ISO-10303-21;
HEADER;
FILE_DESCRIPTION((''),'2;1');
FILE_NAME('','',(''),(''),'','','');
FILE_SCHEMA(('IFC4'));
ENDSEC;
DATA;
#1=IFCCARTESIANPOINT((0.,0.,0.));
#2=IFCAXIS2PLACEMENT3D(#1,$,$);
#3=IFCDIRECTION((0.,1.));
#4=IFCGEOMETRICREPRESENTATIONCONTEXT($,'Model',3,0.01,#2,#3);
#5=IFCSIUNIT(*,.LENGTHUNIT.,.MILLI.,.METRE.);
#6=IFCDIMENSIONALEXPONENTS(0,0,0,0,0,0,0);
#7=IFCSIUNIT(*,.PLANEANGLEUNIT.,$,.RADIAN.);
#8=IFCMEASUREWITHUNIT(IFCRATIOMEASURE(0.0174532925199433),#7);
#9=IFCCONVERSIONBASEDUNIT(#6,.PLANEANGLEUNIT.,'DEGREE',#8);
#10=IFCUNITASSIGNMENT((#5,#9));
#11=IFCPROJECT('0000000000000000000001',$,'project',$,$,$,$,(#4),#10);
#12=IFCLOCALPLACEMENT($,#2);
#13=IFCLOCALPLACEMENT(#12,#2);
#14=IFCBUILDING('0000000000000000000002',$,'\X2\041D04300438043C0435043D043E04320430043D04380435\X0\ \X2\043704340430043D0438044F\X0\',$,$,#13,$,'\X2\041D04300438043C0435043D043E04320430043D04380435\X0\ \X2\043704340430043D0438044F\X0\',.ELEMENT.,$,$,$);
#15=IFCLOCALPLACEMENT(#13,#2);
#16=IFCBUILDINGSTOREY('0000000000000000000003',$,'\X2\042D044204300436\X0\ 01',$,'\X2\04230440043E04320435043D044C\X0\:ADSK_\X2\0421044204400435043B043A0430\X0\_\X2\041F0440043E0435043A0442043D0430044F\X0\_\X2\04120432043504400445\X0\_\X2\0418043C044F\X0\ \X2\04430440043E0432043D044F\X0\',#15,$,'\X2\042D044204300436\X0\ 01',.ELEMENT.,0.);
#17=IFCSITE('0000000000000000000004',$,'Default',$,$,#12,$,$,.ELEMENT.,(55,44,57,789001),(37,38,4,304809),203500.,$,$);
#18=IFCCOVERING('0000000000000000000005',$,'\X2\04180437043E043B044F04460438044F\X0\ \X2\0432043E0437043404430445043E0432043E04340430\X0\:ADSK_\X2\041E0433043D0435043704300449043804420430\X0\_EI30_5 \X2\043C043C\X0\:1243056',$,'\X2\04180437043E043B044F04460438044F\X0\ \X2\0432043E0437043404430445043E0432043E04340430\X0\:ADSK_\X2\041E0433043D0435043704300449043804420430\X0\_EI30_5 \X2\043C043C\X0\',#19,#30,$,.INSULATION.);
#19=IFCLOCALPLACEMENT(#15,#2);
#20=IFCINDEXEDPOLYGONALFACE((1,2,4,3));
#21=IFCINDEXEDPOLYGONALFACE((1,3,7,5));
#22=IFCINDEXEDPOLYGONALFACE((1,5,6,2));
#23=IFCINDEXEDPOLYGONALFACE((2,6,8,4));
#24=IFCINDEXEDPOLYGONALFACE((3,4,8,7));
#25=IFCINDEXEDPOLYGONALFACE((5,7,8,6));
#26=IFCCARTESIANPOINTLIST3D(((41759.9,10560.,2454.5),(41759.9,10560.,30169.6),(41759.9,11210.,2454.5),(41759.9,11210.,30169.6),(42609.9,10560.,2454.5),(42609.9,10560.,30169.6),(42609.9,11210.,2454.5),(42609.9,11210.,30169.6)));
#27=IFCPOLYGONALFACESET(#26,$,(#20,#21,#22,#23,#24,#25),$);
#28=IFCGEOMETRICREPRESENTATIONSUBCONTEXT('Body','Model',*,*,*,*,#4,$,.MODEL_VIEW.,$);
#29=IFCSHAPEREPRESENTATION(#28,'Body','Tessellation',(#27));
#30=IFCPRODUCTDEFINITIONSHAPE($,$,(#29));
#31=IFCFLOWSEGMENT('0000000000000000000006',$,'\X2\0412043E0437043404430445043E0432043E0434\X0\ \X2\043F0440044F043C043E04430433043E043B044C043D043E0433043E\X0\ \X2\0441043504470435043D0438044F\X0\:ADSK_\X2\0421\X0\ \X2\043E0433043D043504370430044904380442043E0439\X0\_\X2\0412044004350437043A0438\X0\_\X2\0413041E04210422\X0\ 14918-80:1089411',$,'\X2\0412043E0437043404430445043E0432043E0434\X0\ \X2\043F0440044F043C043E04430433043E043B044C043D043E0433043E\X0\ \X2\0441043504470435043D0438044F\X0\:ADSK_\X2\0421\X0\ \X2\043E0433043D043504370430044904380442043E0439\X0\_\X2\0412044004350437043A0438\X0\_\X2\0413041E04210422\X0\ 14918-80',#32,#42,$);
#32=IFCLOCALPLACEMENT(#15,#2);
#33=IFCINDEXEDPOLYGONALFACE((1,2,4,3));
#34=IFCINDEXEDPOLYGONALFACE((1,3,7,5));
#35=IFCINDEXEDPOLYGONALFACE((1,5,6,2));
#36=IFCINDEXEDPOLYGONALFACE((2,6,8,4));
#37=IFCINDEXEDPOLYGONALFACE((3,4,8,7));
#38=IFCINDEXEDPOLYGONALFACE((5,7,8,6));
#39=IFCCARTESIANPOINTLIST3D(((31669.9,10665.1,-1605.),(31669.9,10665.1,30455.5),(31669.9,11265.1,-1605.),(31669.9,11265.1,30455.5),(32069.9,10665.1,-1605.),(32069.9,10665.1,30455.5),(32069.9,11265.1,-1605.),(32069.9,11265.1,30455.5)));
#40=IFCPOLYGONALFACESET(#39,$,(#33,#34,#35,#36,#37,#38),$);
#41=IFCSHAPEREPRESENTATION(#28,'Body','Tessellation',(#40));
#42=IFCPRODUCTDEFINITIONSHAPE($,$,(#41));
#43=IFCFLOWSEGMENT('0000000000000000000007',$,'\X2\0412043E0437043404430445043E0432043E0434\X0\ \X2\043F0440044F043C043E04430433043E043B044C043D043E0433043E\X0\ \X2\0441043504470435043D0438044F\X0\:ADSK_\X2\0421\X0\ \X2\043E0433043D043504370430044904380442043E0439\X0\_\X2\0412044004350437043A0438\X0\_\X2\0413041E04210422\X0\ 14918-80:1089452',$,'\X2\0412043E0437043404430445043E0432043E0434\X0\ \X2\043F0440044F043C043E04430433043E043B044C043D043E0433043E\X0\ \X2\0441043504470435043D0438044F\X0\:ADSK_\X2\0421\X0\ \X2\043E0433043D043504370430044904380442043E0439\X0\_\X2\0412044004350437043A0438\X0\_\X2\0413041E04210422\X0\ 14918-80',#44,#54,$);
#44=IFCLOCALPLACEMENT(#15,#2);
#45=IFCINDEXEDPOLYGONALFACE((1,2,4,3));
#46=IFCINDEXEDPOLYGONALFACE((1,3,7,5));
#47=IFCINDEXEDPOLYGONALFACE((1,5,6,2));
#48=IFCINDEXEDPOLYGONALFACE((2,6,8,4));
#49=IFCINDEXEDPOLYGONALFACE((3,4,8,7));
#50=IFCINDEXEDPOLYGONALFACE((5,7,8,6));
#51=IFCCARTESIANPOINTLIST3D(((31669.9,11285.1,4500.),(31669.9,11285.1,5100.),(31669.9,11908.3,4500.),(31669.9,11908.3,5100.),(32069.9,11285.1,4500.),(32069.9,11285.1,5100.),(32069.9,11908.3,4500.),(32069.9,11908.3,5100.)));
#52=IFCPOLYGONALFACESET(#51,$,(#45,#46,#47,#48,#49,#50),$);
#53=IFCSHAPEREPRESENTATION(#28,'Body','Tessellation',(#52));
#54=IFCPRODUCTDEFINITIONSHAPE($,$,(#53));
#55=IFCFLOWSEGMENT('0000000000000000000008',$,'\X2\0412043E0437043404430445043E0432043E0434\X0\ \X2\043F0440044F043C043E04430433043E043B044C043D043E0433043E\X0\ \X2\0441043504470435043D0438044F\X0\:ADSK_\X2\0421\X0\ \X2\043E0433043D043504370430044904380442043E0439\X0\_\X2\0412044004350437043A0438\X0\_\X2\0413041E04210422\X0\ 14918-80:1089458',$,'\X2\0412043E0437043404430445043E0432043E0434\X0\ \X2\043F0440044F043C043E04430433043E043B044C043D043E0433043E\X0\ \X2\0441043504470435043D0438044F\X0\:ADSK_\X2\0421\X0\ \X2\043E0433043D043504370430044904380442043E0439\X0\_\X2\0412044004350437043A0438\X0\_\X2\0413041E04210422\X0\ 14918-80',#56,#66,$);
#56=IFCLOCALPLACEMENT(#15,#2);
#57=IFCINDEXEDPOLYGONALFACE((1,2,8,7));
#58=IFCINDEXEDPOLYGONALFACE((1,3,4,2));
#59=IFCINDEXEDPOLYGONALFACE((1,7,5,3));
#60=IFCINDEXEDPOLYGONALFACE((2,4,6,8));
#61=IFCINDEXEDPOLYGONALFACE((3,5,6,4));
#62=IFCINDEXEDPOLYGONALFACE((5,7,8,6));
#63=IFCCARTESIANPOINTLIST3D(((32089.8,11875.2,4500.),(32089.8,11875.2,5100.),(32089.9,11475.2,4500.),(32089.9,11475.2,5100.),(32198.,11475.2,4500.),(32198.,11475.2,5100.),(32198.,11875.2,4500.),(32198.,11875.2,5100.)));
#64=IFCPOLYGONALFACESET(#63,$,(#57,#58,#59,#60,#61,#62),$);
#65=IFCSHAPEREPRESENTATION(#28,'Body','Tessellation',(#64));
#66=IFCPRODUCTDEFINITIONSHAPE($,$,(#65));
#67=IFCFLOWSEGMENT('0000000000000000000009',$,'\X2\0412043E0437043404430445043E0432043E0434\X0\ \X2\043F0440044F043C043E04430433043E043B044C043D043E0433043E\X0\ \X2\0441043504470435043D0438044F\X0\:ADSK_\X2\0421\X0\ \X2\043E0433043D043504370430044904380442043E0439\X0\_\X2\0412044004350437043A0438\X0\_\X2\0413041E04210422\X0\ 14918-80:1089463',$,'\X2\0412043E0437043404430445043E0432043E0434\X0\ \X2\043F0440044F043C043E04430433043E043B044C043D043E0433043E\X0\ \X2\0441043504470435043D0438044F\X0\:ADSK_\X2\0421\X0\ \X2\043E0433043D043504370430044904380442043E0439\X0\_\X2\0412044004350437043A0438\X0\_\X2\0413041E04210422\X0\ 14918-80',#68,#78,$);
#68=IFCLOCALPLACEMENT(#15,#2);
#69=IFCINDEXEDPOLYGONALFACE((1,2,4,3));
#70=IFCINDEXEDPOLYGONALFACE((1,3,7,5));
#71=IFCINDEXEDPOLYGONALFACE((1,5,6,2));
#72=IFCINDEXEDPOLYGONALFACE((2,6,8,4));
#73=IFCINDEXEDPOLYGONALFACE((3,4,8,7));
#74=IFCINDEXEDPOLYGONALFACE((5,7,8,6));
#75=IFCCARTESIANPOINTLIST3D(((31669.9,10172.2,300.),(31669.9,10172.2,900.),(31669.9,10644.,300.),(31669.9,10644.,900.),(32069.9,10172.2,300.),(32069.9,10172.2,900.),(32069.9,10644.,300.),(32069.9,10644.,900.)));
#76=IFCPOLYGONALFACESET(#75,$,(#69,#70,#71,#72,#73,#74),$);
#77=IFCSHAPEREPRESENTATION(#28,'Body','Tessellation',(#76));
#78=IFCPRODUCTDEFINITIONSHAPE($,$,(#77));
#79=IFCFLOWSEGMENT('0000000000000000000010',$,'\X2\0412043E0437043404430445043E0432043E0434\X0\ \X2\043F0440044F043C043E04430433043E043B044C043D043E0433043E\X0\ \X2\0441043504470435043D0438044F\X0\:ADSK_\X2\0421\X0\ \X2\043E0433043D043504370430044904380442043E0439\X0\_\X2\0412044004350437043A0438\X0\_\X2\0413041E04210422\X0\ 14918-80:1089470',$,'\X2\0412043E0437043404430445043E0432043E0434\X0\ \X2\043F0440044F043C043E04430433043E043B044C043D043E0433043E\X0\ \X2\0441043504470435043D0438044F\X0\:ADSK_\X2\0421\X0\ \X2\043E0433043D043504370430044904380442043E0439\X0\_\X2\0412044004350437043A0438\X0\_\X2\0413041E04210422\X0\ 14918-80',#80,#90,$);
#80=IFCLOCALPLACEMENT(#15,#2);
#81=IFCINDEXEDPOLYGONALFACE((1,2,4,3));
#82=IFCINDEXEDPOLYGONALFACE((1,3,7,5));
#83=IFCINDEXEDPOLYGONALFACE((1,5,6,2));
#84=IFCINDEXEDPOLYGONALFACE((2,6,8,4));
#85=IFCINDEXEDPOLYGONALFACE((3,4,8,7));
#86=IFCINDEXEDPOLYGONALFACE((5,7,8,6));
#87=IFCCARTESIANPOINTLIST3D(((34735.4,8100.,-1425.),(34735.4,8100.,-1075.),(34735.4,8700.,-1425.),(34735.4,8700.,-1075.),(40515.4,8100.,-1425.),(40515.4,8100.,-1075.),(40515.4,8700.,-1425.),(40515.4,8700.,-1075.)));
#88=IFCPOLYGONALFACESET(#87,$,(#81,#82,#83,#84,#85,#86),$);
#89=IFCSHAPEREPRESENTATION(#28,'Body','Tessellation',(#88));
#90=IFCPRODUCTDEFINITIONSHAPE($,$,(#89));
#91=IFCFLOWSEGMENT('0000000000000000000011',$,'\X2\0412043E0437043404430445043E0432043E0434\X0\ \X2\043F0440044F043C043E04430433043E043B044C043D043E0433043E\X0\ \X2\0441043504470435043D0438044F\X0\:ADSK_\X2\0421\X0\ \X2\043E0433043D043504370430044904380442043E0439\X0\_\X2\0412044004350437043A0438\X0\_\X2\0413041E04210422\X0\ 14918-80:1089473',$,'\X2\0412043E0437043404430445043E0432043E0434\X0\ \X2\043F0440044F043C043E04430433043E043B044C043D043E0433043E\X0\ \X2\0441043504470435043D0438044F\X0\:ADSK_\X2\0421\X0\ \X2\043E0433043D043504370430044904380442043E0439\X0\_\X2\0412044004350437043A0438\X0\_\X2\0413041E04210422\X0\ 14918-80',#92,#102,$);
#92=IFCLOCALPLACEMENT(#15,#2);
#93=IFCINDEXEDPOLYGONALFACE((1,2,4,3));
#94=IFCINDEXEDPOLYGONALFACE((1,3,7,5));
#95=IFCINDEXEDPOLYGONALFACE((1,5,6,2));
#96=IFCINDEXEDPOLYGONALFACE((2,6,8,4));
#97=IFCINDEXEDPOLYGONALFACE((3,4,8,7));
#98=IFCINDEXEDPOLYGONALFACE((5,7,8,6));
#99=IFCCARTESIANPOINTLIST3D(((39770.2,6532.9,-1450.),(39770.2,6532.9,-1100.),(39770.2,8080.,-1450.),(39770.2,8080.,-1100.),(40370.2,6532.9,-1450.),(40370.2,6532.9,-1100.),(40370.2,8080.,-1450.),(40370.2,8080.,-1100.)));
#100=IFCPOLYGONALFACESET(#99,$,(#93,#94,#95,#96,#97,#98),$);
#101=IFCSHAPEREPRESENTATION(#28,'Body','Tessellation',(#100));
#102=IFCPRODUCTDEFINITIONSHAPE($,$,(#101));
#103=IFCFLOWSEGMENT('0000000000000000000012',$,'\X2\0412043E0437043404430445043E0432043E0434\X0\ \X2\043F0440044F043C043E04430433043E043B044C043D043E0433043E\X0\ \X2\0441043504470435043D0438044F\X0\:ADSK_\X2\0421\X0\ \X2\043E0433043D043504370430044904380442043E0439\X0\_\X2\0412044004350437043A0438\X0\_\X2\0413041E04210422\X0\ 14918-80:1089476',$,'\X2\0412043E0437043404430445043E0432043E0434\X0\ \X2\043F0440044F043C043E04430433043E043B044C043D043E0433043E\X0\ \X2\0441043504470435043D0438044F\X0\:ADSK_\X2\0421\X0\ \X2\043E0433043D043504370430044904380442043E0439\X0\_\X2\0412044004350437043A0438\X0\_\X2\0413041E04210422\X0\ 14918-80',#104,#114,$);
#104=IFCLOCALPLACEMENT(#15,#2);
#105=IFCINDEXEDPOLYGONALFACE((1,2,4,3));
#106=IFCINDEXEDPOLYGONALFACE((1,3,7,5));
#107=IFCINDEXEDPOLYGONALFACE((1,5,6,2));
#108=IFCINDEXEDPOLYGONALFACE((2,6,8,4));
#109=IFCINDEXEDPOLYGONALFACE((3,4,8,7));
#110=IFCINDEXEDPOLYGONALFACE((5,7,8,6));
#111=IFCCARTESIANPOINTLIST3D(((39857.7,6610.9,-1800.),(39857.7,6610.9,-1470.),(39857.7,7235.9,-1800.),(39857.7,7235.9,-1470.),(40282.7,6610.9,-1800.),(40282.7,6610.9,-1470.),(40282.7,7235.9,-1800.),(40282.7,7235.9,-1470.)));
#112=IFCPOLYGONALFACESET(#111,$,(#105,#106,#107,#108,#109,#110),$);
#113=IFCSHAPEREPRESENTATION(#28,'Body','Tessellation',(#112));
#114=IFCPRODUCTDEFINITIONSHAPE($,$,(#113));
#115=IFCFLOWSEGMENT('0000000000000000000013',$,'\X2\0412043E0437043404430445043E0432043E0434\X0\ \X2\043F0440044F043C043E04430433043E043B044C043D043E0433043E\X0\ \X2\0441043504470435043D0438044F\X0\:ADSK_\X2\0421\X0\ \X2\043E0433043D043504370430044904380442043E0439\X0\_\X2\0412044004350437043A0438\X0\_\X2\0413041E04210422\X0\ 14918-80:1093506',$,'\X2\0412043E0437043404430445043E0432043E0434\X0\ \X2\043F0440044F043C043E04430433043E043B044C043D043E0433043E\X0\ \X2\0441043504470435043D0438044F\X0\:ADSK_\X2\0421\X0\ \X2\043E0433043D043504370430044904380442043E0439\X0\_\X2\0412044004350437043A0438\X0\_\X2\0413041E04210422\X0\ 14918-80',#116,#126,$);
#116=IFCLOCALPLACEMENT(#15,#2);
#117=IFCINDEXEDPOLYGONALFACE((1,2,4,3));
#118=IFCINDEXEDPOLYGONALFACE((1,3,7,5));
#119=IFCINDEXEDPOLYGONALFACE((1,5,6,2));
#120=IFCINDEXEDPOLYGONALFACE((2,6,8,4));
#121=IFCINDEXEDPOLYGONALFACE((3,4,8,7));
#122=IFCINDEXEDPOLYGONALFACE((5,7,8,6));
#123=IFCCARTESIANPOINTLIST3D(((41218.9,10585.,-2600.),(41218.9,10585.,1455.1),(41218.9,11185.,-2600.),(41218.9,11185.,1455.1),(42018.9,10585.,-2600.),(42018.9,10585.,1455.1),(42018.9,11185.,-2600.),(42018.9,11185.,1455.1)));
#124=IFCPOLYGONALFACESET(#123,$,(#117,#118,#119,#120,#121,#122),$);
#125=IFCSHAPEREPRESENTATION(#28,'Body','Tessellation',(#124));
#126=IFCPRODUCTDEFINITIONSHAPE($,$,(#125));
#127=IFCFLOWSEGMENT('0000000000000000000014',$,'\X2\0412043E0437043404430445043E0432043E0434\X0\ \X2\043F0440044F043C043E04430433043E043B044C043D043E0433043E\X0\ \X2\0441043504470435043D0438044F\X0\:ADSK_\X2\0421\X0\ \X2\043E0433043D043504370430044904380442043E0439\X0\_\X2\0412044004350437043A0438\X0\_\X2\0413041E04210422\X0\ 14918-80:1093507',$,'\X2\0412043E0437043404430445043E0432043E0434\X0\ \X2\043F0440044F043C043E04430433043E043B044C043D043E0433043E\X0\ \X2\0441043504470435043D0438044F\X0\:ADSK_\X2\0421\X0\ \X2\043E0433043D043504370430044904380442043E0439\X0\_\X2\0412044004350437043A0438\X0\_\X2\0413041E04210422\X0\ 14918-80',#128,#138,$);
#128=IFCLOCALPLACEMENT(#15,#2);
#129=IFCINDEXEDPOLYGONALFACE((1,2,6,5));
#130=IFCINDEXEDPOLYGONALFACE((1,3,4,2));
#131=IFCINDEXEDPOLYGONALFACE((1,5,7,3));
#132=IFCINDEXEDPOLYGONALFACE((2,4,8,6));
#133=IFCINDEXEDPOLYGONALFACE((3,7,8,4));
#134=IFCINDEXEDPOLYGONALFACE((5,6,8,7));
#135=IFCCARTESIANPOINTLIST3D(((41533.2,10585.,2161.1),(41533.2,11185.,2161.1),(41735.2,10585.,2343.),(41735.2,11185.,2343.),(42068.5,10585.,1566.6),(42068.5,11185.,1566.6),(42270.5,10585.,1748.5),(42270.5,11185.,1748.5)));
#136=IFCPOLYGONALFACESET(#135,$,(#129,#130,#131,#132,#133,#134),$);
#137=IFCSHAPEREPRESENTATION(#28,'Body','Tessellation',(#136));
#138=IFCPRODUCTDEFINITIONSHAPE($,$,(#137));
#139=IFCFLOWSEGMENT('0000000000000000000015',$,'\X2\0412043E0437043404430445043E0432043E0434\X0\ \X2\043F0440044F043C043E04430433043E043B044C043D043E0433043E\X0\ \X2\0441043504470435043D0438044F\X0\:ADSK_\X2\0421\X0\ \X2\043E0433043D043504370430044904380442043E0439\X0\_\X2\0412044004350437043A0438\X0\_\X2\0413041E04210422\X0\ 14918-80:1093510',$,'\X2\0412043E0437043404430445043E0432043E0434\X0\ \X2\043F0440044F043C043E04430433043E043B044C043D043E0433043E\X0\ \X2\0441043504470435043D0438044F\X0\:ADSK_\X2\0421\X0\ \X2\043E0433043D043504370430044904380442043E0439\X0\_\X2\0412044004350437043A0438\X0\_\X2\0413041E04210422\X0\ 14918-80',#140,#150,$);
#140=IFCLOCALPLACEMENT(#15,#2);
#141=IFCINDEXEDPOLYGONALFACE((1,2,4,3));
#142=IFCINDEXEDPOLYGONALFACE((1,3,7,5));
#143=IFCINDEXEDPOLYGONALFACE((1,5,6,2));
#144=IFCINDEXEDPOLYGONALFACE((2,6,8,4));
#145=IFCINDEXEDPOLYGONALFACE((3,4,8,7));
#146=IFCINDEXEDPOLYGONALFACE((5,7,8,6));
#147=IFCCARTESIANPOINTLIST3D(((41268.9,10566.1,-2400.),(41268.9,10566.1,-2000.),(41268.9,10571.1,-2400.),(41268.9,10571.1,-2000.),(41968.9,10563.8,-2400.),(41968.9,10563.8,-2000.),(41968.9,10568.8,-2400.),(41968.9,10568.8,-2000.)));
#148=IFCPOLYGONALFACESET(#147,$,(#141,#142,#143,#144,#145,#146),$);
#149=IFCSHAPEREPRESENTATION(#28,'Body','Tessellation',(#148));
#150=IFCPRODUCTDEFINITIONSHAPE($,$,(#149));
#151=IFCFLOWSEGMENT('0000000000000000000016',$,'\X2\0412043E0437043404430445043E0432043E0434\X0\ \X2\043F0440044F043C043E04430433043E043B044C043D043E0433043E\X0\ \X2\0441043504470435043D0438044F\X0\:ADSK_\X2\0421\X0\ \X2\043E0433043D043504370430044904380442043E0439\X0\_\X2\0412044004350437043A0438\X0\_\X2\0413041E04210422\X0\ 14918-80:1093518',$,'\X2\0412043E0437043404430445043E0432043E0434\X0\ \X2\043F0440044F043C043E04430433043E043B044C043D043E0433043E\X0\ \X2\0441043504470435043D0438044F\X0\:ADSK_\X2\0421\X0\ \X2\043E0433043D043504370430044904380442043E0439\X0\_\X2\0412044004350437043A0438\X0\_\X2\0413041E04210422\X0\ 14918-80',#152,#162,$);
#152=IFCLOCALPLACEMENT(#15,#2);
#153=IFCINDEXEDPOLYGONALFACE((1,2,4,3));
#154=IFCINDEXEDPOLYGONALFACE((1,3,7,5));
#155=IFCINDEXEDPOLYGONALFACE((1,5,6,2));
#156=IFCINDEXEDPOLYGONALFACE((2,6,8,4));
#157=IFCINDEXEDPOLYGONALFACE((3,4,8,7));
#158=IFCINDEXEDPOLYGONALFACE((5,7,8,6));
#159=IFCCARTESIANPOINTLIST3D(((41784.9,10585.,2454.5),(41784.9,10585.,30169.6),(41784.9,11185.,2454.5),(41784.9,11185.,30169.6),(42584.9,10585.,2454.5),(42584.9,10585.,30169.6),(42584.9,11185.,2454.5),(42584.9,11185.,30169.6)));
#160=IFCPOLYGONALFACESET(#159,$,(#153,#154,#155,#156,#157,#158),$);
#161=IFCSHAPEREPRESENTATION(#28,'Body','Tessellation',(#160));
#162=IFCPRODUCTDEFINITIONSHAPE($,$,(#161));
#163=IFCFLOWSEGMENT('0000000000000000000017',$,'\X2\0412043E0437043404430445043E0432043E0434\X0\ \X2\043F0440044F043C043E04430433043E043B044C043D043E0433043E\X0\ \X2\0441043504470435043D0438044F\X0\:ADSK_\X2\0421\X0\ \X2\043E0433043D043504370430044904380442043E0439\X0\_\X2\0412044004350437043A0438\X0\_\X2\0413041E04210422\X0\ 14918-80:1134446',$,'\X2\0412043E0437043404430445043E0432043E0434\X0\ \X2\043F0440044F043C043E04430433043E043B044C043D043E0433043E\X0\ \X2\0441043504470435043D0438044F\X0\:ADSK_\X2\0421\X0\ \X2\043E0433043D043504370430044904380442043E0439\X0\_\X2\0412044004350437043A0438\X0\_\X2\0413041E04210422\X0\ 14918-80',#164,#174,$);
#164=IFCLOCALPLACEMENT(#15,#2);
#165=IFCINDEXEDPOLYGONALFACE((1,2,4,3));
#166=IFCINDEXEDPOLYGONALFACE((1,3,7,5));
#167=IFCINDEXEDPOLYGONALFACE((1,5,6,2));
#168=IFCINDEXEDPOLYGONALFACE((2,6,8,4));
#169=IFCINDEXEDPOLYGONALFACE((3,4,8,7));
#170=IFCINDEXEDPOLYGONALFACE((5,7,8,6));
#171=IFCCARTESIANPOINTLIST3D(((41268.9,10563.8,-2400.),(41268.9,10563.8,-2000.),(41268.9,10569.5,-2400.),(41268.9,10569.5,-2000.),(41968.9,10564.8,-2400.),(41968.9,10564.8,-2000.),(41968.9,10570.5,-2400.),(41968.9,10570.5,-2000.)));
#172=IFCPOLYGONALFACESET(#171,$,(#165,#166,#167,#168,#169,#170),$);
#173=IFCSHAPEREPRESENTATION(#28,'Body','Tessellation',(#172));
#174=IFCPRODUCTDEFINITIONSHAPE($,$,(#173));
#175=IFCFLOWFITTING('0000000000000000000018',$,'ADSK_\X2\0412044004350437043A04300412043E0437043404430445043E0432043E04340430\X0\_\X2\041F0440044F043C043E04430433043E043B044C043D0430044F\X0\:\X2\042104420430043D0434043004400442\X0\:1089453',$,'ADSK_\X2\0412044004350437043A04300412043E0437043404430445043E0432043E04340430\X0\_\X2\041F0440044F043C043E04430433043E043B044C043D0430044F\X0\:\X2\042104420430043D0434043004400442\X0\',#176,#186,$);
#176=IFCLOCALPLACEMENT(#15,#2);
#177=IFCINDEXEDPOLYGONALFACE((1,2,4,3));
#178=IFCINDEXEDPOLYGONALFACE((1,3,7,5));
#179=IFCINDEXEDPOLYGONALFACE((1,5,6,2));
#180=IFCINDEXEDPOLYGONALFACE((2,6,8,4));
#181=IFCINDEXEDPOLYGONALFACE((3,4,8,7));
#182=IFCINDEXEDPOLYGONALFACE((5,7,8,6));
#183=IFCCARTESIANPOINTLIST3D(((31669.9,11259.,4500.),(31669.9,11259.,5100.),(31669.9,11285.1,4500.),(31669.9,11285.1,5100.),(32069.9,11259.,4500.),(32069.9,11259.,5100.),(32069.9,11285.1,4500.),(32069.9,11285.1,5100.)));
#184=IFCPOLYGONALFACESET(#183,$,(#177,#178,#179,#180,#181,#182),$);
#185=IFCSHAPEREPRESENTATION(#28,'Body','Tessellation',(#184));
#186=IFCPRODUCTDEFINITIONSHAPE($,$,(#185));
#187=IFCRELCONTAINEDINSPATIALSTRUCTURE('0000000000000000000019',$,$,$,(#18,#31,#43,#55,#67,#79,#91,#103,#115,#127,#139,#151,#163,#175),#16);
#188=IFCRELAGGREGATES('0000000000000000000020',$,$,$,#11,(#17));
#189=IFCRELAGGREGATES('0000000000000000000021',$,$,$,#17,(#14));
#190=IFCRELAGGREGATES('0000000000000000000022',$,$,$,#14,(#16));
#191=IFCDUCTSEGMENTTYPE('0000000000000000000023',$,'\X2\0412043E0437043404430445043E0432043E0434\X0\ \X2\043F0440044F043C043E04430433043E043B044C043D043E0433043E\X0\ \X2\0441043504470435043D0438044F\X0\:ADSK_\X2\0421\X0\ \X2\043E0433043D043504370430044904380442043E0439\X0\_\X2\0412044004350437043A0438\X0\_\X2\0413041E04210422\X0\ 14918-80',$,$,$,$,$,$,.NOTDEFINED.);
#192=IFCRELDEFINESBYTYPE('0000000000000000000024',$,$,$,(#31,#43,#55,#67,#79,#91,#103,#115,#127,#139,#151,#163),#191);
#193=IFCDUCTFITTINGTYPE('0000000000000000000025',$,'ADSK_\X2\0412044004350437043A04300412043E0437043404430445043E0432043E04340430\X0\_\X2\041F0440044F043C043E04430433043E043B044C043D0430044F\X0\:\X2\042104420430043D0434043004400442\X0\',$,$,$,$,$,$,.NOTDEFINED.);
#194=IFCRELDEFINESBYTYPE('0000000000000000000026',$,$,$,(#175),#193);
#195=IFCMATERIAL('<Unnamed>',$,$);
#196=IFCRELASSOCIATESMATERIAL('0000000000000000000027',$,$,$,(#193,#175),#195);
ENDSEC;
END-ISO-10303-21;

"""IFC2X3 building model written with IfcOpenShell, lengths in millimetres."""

from ifc_helpers import new_model, entity, si_unit, converted_unit, direction, frame, frame_2d, origin, origin_2d_with_axis, place, context, subcontext, project, spatial, rectangle, extrude, source, transform, mapped, material, type_object, type_shapes, element, save


model = new_model("IFC2X3")

# Units and contexts
model_context = context("Model", 3, precision=0.01, world=origin(), true_north=direction((0.0, 1.0)))
body_context = subcontext(model_context, "Body", "Model", "MODEL_VIEW")
ifc_project = project(units=[si_unit("LENGTHUNIT", "METRE", prefix="MILLI"), converted_unit("PLANEANGLEUNIT", "DEGREE", entity("IfcRatioMeasure", 0.0174532925199433), si_unit("PLANEANGLEUNIT", "RADIAN"), dimensions=[0, 0, 0, 0, 0, 0, 0])], contexts=[model_context])

# Site, building, storey
site_placement = place(None, frame((0.0, 0.0, 0.0)))
site = spatial("IfcSite", under=ifc_project, at=site_placement, Name="Default", CompositionType="ELEMENT", RefLatitude=(55, 44, 57, 789001), RefLongitude=(37, 38, 4, 304809), RefElevation=203500.0)
building_placement = place(site_placement, origin())
building = spatial("IfcBuilding", under=site, at=building_placement, Name="Наименование здания", LongName="Наименование здания", CompositionType="ELEMENT")
storey_placement = place(building_placement, origin())
storey = spatial("IfcBuildingStorey", under=building, at=storey_placement, Name="Этаж 01", ObjectType="Уровень:ADSK_Стрелка_Проектная_Вверх_Имя уровня", LongName="Этаж 01", CompositionType="ELEMENT", Elevation=0.0)

# Covering
covering_placement = place(storey_placement, frame((41759.9, 10560.0, 2454.5)))
element("IfcCovering", 1, at=covering_placement, inside=storey, Name="Изоляция воздуховода:ADSK_Огнезащита_EI30_5 мм:1243056", ObjectType="Изоляция воздуховода:ADSK_Огнезащита_EI30_5 мм", PredefinedType="INSULATION", context=body_context, shape_type="SweptSolid", body=[
    extrude(rectangle(XDim=850.0, YDim=650.0, at=origin_2d_with_axis()), frame((425.0, 325.0, 0.0), z_axis=(0.0, 0.0, 1.0), x_axis=(-1.0, 0.0, 0.0)), (0.0, 0.0, 1.0), 27715.1),
])

# Flow segments
duct_segment_type = type_object("IfcDuctSegmentType", Name="Воздуховод прямоугольного сечения:ADSK_С огнезащитой_Врезки_ГОСТ 14918-80", PredefinedType="NOTDEFINED")
flow_segment_1_placement = place(storey_placement, frame((31669.9, 10665.1, -1605.0)))
element("IfcFlowSegment", 2, at=flow_segment_1_placement, inside=storey, type_object=duct_segment_type, Name="Воздуховод прямоугольного сечения:ADSK_С огнезащитой_Врезки_ГОСТ 14918-80:1089411", ObjectType="Воздуховод прямоугольного сечения:ADSK_С огнезащитой_Врезки_ГОСТ 14918-80", context=body_context, shape_type="SweptSolid", body=[
    extrude(rectangle(XDim=600.0, YDim=400.0, at=frame_2d((0.0, 0.0), x_axis=(1.0, 0.0))), frame((200.0, 300.0, 0.0), z_axis=(0.0, 0.0, 1.0), x_axis=(0.0, -1.0, 0.0)), (0.0, 0.0, 1.0), 32060.5),
])
flow_segment_2_placement = place(storey_placement, frame((31669.9, 11285.1, 4500.0)))
element("IfcFlowSegment", 3, at=flow_segment_2_placement, inside=storey, type_object=duct_segment_type, Name="Воздуховод прямоугольного сечения:ADSK_С огнезащитой_Врезки_ГОСТ 14918-80:1089452", ObjectType="Воздуховод прямоугольного сечения:ADSK_С огнезащитой_Врезки_ГОСТ 14918-80", context=body_context, shape_type="SweptSolid", body=[
    extrude(rectangle(XDim=623.2, YDim=400.0, at=frame_2d((0.0, 0.0), x_axis=(1.0, 0.0))), frame((200.0, 311.6, 0.0), z_axis=(0.0, 0.0, 1.0), x_axis=(0.0, 1.0, 0.0)), (0.0, 0.0, 1.0), 600.0),
])
flow_segment_3_placement = place(storey_placement, frame((32089.8, 11475.2, 4500.0)))
element("IfcFlowSegment", 4, at=flow_segment_3_placement, inside=storey, type_object=duct_segment_type, Name="Воздуховод прямоугольного сечения:ADSK_С огнезащитой_Врезки_ГОСТ 14918-80:1089458", ObjectType="Воздуховод прямоугольного сечения:ADSK_С огнезащитой_Врезки_ГОСТ 14918-80", context=body_context, shape_type="SweptSolid", body=[
    extrude(rectangle(XDim=108.1, YDim=400.0, at=origin_2d_with_axis()), frame((54.1, 200.0, 0.0), z_axis=(0.0, 0.0, 1.0), x_axis=(1.0, 0.000152, 0.0)), (0.0, 0.0, 1.0), 600.0),
])
flow_segment_4_placement = place(storey_placement, frame((31669.9, 10172.2, 300.0)))
element("IfcFlowSegment", 5, at=flow_segment_4_placement, inside=storey, type_object=duct_segment_type, Name="Воздуховод прямоугольного сечения:ADSK_С огнезащитой_Врезки_ГОСТ 14918-80:1089463", ObjectType="Воздуховод прямоугольного сечения:ADSK_С огнезащитой_Врезки_ГОСТ 14918-80", context=body_context, shape_type="SweptSolid", body=[
    extrude(rectangle(XDim=471.8, YDim=400.0, at=frame_2d((0.0, 0.0), x_axis=(1.0, 0.0))), frame((200.0, 235.9, 0.0), z_axis=(0.0, 0.0, 1.0), x_axis=(0.000035, -1.0, 0.0)), (0.0, 0.0, 1.0), 600.0),
])
flow_segment_5_placement = place(storey_placement, frame((34735.4, 8100.0, -1425.0)))
element("IfcFlowSegment", 6, at=flow_segment_5_placement, inside=storey, type_object=duct_segment_type, Name="Воздуховод прямоугольного сечения:ADSK_С огнезащитой_Врезки_ГОСТ 14918-80:1089470", ObjectType="Воздуховод прямоугольного сечения:ADSK_С огнезащитой_Врезки_ГОСТ 14918-80", context=body_context, shape_type="SweptSolid", body=[
    extrude(rectangle(XDim=5780.0, YDim=600.0, at=origin_2d_with_axis()), frame((2890.0, 300.0, 0.0), z_axis=(0.0, 0.0, 1.0), x_axis=(-1.0, 0.0, 0.0)), (0.0, 0.0, 1.0), 350.0),
])
flow_segment_6_placement = place(storey_placement, frame((39770.2, 6532.9, -1450.0)))
element("IfcFlowSegment", 7, at=flow_segment_6_placement, inside=storey, type_object=duct_segment_type, Name="Воздуховод прямоугольного сечения:ADSK_С огнезащитой_Врезки_ГОСТ 14918-80:1089473", ObjectType="Воздуховод прямоугольного сечения:ADSK_С огнезащитой_Врезки_ГОСТ 14918-80", context=body_context, shape_type="SweptSolid", body=[
    extrude(rectangle(XDim=1547.1, YDim=600.0, at=frame_2d((0.0, 0.0), x_axis=(1.0, 0.0))), frame((300.0, 773.6, 0.0), z_axis=(0.0, 0.0, 1.0), x_axis=(0.0, 1.0, 0.0)), (0.0, 0.0, 1.0), 350.0),
])
flow_segment_7_placement = place(storey_placement, frame((39857.7, 6610.9, -1800.0)))
element("IfcFlowSegment", 8, at=flow_segment_7_placement, inside=storey, type_object=duct_segment_type, Name="Воздуховод прямоугольного сечения:ADSK_С огнезащитой_Врезки_ГОСТ 14918-80:1089476", ObjectType="Воздуховод прямоугольного сечения:ADSK_С огнезащитой_Врезки_ГОСТ 14918-80", context=body_context, shape_type="SweptSolid", body=[
    extrude(rectangle(XDim=625.0, YDim=425.0, at=frame_2d((0.0, 0.0), x_axis=(1.0, 0.0))), frame((212.5, 312.5, 0.0), z_axis=(0.0, 0.0, 1.0), x_axis=(0.0, -1.0, 0.0)), (0.0, 0.0, 1.0), 330.0),
])
flow_segment_8_placement = place(storey_placement, frame((41218.9, 10585.0, -2600.0)))
element("IfcFlowSegment", 9, at=flow_segment_8_placement, inside=storey, type_object=duct_segment_type, Name="Воздуховод прямоугольного сечения:ADSK_С огнезащитой_Врезки_ГОСТ 14918-80:1093506", ObjectType="Воздуховод прямоугольного сечения:ADSK_С огнезащитой_Врезки_ГОСТ 14918-80", context=body_context, shape_type="SweptSolid", body=[
    extrude(rectangle(XDim=600.0, YDim=800.0, at=frame_2d((0.0, 0.0), x_axis=(1.0, 0.0))), frame((400.0, 300.0, 0.0), z_axis=(0.0, 0.0, 1.0), x_axis=(0.0, -1.0, 0.0)), (0.0, 0.0, 1.0), 4055.1),
])
flow_segment_9_placement = place(storey_placement, frame((41533.2, 10585.0, 1566.6)))
element("IfcFlowSegment", 10, at=flow_segment_9_placement, inside=storey, type_object=duct_segment_type, Name="Воздуховод прямоугольного сечения:ADSK_С огнезащитой_Врезки_ГОСТ 14918-80:1093507", ObjectType="Воздуховод прямоугольного сечения:ADSK_С огнезащитой_Врезки_ГОСТ 14918-80", context=body_context, shape_type="SweptSolid", body=[
    extrude(rectangle(XDim=271.9, YDim=600.0, at=frame_2d((0.0, 0.0), x_axis=(1.0, 0.0))), frame((636.3, 300.0, 91.0), z_axis=(-0.669131, 0.0, 0.743145), x_axis=(-0.743145, 0.0, -0.669131)), (0.0, 0.0, 1.0), 800.0),
])
flow_segment_10_placement = place(storey_placement, frame((41268.9, 10563.8, -2400.0)))
element("IfcFlowSegment", 11, at=flow_segment_10_placement, inside=storey, type_object=duct_segment_type, Name="Воздуховод прямоугольного сечения:ADSK_С огнезащитой_Врезки_ГОСТ 14918-80:1093510", ObjectType="Воздуховод прямоугольного сечения:ADSK_С огнезащитой_Врезки_ГОСТ 14918-80", context=body_context, shape_type="SweptSolid", body=[
    extrude(rectangle(XDim=5.0, YDim=700.0, at=frame_2d((0.0, 0.0), x_axis=(1.0, 0.0))), frame((350.0, 3.7, 0.0), z_axis=(0.0, 0.0, 1.0), x_axis=(0.003286, 0.999995, 0.0)), (0.0, 0.0, 1.0), 400.0),
])
flow_segment_11_placement = place(storey_placement, frame((41784.9, 10585.0, 2454.5)))
element("IfcFlowSegment", 12, at=flow_segment_11_placement, inside=storey, type_object=duct_segment_type, Name="Воздуховод прямоугольного сечения:ADSK_С огнезащитой_Врезки_ГОСТ 14918-80:1093518", ObjectType="Воздуховод прямоугольного сечения:ADSK_С огнезащитой_Врезки_ГОСТ 14918-80", context=body_context, shape_type="SweptSolid", body=[
    extrude(rectangle(XDim=800.0, YDim=600.0, at=frame_2d((0.0, 0.0), x_axis=(1.0, 0.0))), frame((400.0, 300.0, 0.0)), (0.0, 0.0, 1.0), 27715.1),
])
flow_segment_12_placement = place(storey_placement, frame((41268.9, 10563.8, -2400.0)))
element("IfcFlowSegment", 13, at=flow_segment_12_placement, inside=storey, type_object=duct_segment_type, Name="Воздуховод прямоугольного сечения:ADSK_С огнезащитой_Врезки_ГОСТ 14918-80:1134446", ObjectType="Воздуховод прямоугольного сечения:ADSK_С огнезащитой_Врезки_ГОСТ 14918-80", context=body_context, shape_type="SweptSolid", body=[
    extrude(rectangle(XDim=5.7, YDim=700.0, at=origin_2d_with_axis()), frame((350.0, 3.4, 0.0), z_axis=(0.0, 0.0, 1.0), x_axis=(-0.001494, 0.999999, 0.0)), (0.0, 0.0, 1.0), 400.0),
])

# Flow fitting
ifc_material_1 = material(Name="<Unnamed>")
duct_fitting_type_1 = type_object("IfcDuctFittingType", Name="ADSK_ВрезкаВоздуховода_Прямоугольная:Стандарт", PredefinedType="NOTDEFINED", material=ifc_material_1)
shared_shape_1 = source(origin(), body_context, "Body", "SweptSolid", [
    extrude(rectangle(XDim=26.1, YDim=600.0, at=frame_2d((0.0, 0.0), x_axis=(1.0, 0.0))), frame((7.0, 0.0, -200.0)), (0.0, 0.0, 1.0), 400.0),
])
type_shapes(duct_fitting_type_1, [shared_shape_1])
flow_fitting_1_placement = place(storey_placement, frame((31869.9, 11265.1, 4800.0), z_axis=(1.0, 0.0, 0.0), x_axis=(0.0, 1.0, 0.0)))
element("IfcFlowFitting", 14, at=flow_fitting_1_placement, inside=storey, type_object=duct_fitting_type_1, material=ifc_material_1, Name="ADSK_ВрезкаВоздуховода_Прямоугольная:Стандарт:1089453", ObjectType="ADSK_ВрезкаВоздуховода_Прямоугольная:Стандарт", context=body_context, shape_type="MappedRepresentation", body=[
    mapped(shared_shape_1, transform((0.0, 0.0, 0.0), scale=1.0)),
])

save(model, "model.ifc")
